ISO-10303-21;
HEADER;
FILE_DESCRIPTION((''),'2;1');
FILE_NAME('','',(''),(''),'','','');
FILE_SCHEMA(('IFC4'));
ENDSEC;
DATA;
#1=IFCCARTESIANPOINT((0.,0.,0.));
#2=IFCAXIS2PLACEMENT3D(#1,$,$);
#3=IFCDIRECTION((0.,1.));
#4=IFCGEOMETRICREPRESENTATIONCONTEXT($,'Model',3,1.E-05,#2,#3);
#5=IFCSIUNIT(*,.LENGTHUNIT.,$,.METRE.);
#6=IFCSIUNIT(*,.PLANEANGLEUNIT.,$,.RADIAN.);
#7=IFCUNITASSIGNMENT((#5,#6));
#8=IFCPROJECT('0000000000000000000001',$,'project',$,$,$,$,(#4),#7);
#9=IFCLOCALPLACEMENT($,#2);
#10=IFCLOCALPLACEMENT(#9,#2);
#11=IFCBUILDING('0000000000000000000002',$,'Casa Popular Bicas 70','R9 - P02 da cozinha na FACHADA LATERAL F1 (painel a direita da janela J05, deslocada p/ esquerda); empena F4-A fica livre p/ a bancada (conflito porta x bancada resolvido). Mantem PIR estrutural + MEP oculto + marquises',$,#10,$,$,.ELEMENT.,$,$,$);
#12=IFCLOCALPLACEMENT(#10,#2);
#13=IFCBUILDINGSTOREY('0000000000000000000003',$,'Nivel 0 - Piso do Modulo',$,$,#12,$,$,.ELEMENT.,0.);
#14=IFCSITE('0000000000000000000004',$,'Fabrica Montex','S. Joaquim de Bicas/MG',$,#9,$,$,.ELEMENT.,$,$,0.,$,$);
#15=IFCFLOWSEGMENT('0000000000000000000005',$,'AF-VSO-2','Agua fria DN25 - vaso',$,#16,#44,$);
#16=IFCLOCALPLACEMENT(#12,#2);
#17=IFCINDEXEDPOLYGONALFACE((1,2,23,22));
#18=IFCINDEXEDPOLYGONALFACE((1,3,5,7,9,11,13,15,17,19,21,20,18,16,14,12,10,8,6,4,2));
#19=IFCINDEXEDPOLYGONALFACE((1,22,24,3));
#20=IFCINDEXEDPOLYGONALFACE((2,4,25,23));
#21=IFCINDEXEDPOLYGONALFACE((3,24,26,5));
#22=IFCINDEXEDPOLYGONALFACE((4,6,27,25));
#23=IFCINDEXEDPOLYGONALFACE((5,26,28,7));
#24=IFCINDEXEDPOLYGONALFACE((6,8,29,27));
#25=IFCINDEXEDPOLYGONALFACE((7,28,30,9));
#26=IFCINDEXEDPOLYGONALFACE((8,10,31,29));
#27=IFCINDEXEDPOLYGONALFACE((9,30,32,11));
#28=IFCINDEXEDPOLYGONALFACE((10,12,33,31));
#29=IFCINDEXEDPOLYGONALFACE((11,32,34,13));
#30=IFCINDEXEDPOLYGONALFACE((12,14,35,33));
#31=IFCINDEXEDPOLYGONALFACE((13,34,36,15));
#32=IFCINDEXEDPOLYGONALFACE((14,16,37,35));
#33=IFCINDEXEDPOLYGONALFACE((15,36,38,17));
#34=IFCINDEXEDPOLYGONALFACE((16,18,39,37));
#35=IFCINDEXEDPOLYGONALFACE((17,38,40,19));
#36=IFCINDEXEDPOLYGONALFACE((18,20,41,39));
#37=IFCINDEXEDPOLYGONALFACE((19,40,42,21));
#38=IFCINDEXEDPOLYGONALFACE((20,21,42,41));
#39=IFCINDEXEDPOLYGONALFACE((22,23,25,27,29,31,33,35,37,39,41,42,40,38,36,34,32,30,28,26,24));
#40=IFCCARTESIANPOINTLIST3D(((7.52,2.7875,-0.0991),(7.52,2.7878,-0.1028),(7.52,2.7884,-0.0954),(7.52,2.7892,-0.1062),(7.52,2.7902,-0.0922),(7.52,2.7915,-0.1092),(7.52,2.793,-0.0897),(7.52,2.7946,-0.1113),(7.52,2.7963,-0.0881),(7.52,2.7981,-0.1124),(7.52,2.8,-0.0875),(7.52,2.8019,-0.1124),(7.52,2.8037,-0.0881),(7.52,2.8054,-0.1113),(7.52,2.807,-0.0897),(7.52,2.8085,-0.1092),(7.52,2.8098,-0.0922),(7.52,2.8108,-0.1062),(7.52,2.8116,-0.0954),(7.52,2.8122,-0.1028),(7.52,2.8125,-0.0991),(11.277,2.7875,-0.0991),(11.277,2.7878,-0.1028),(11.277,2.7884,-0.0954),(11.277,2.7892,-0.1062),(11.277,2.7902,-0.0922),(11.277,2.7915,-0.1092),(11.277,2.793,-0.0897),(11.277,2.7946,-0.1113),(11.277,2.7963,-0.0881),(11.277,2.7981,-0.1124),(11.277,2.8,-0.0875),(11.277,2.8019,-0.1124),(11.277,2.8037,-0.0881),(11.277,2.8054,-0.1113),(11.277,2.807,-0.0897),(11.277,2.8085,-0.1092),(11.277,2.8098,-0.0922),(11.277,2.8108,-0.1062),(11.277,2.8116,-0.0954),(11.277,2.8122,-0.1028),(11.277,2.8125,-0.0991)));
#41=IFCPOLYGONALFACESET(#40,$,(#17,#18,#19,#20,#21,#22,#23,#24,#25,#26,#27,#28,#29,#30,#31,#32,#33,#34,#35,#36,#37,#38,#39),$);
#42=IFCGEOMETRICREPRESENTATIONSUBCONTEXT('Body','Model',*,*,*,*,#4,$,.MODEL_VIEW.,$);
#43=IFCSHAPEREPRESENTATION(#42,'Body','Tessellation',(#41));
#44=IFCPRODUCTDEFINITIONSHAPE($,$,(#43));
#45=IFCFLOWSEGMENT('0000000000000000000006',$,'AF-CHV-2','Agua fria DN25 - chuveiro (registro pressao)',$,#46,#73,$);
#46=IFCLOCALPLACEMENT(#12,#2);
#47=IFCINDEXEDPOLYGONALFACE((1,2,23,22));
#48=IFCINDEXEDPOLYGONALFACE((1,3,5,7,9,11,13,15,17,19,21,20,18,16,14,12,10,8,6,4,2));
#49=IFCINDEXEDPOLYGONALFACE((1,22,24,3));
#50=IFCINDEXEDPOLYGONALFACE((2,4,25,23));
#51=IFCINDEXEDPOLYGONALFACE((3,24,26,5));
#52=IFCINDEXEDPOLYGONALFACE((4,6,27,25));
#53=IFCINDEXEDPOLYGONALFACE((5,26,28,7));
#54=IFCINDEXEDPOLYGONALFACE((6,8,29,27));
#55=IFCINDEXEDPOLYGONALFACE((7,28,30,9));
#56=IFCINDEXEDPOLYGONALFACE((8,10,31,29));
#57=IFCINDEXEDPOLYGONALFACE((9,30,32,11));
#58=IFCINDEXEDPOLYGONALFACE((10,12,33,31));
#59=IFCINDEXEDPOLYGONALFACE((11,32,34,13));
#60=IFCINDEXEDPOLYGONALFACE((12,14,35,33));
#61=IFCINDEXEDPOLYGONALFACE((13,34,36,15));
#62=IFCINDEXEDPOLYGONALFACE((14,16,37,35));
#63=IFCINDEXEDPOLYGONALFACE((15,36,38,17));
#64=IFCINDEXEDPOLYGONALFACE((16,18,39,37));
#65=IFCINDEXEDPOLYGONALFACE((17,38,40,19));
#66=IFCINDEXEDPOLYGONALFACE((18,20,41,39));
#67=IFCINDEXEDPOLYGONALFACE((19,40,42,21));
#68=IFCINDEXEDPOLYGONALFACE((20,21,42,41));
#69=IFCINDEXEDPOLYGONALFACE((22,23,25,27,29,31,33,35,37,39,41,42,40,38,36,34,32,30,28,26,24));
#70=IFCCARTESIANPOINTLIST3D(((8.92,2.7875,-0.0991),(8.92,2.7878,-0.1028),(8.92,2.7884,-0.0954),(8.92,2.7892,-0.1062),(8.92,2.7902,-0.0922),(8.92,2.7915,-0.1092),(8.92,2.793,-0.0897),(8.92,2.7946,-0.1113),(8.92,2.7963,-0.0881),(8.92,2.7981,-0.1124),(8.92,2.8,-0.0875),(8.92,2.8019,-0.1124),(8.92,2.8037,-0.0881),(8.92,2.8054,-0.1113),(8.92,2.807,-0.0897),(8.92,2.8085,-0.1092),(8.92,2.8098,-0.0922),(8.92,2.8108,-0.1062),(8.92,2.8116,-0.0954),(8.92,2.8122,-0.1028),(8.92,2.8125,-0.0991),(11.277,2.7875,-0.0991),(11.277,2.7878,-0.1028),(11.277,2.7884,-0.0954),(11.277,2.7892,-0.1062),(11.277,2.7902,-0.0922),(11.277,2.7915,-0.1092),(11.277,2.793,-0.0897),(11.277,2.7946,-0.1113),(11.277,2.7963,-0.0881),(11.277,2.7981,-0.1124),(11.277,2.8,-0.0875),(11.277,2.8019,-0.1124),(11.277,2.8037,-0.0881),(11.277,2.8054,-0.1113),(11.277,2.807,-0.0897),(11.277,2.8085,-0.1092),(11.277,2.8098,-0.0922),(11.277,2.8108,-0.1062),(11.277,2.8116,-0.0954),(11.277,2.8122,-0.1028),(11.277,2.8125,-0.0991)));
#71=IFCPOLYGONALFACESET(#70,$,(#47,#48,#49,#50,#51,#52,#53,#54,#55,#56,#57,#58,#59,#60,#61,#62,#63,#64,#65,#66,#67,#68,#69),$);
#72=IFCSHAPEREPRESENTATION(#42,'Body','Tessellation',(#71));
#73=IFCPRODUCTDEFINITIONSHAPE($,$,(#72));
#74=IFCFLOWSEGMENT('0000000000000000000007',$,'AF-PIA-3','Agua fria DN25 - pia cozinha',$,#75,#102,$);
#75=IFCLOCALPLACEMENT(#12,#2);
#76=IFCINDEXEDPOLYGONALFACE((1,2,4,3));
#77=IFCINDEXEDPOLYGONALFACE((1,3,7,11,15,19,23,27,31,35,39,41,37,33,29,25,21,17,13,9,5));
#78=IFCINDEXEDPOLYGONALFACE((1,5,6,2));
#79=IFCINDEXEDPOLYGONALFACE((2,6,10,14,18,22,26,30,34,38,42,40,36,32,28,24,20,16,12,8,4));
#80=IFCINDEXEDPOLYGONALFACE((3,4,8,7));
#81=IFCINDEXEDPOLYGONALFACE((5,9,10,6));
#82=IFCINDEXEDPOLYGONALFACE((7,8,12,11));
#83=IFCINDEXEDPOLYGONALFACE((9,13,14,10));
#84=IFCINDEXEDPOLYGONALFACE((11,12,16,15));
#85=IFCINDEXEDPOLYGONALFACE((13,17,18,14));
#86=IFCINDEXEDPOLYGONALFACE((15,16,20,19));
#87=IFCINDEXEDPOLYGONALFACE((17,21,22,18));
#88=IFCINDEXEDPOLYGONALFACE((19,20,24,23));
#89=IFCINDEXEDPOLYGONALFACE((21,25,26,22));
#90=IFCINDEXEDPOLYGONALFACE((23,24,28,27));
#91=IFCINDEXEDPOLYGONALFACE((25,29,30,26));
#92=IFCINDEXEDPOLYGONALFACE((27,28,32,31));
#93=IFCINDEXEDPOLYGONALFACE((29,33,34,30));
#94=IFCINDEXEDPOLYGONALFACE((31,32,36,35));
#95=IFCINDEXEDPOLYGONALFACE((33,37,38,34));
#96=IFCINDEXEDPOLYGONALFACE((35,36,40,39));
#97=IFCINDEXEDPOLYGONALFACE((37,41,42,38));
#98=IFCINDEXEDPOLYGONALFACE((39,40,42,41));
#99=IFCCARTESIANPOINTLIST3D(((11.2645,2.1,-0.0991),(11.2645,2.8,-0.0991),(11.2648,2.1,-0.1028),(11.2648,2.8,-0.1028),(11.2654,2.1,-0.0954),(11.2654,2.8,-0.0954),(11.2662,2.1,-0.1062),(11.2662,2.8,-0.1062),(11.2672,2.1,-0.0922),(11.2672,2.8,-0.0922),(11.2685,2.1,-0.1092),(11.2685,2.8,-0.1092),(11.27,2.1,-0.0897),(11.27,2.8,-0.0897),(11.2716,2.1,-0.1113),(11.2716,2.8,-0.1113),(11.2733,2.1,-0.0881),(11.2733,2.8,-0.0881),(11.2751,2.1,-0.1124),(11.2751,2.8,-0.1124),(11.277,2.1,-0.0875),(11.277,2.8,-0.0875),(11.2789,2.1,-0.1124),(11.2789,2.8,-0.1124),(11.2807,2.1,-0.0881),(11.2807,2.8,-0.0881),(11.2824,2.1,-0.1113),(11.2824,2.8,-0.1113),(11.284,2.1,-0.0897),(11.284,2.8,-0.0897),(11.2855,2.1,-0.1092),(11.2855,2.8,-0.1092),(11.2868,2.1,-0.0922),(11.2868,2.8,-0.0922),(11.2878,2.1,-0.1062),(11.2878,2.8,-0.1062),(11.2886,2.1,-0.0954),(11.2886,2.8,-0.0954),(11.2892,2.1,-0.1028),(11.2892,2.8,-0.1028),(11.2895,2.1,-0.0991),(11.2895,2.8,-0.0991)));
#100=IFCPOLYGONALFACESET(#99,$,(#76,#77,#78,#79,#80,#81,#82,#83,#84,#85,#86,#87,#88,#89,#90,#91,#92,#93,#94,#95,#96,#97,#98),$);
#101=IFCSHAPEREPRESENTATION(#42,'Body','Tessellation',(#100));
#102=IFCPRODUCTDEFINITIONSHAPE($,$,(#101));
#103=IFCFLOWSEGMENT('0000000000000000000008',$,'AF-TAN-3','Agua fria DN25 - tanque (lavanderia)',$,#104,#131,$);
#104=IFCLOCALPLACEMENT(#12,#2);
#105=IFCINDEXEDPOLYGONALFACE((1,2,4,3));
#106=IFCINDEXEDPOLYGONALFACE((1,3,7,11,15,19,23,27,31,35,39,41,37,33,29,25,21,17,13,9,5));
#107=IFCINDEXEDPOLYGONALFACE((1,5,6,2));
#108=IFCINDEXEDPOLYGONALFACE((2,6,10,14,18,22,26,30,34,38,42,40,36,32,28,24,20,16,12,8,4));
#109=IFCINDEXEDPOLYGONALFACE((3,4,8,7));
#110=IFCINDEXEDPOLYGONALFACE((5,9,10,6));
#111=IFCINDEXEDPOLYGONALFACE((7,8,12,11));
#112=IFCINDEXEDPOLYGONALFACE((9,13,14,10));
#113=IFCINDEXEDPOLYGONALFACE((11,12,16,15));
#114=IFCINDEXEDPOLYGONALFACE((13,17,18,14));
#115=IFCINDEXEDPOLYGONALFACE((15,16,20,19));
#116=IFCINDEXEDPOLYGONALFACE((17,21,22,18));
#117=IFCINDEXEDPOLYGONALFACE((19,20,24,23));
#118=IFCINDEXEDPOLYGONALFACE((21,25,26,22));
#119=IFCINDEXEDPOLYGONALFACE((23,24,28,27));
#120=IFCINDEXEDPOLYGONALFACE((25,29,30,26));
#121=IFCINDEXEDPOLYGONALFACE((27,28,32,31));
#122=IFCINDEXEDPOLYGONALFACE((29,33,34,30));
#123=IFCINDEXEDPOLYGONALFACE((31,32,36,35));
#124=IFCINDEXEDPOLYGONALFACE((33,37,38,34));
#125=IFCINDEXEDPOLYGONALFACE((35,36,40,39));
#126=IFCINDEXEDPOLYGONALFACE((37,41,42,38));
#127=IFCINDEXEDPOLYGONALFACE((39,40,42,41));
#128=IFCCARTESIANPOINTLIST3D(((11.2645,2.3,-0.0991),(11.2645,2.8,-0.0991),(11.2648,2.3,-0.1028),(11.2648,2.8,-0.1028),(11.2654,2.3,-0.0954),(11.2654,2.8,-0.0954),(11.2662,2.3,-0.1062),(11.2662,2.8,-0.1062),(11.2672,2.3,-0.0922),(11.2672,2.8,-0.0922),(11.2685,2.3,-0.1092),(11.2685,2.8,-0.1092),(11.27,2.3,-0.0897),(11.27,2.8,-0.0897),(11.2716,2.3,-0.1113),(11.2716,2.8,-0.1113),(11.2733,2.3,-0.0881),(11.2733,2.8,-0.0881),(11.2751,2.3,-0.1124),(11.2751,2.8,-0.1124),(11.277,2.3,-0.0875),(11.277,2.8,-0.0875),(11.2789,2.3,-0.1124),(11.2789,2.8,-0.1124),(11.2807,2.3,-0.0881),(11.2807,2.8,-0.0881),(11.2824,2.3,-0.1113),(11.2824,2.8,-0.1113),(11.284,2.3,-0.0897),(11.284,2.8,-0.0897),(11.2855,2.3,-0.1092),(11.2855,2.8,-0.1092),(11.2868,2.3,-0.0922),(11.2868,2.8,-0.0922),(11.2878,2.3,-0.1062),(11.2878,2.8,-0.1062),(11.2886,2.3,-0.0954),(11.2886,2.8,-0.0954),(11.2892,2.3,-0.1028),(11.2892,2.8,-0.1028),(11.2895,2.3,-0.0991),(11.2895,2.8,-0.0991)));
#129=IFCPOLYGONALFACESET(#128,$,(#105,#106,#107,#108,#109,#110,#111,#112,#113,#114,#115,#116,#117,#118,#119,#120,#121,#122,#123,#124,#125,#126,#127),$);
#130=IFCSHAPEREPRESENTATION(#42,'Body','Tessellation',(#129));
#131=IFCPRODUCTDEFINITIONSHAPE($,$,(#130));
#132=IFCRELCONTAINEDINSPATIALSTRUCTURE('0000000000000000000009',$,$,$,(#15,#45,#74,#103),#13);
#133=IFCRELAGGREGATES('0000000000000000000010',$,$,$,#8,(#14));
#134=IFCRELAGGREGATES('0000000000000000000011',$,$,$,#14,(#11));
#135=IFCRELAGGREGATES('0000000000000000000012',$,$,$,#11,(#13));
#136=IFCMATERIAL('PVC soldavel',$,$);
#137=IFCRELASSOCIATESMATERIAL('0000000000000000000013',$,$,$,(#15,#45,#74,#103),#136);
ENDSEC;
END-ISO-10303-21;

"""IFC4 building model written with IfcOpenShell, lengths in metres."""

from ifc_helpers import new_model, si_unit, direction, frame, origin, origin_2d, place, context, subcontext, project, spatial, circle, extrude, material, element, save


model = new_model("IFC4")

# Units and contexts
model_context = context("Model", 3, precision=1e-05, world=origin(), true_north=direction((0.0, 1.0)))
body_context = subcontext(model_context, "Body", "Model", "MODEL_VIEW")
ifc_project = project(units=[si_unit("LENGTHUNIT", "METRE"), si_unit("PLANEANGLEUNIT", "RADIAN")], contexts=[model_context])

# Site, building, storey
site_placement = place(None, origin())
site = spatial("IfcSite", under=ifc_project, at=site_placement, Name="Fabrica Montex", Description="S. Joaquim de Bicas/MG", CompositionType="ELEMENT", RefElevation=0.0)
building_placement = place(site_placement, origin())
building = spatial("IfcBuilding", under=site, at=building_placement, Name="Casa Popular Bicas 70", Description="R9 - P02 da cozinha na FACHADA LATERAL F1 (painel a direita da janela J05, deslocada p/ esquerda); empena F4-A fica livre p/ a bancada (conflito porta x bancada resolvido). Mantem PIR estrutural + MEP oculto + marquises", CompositionType="ELEMENT")
storey_placement = place(building_placement, origin())
storey = spatial("IfcBuildingStorey", under=building, at=storey_placement, Name="Nivel 0 - Piso do Modulo", CompositionType="ELEMENT", Elevation=0.0)

# Flow segments
ifc_material_1 = material(Name="PVC soldavel")
flow_segment_1_placement = place(None, frame((11.277, 2.8, -0.1), z_axis=(-1.0, 0.0, 0.0), x_axis=(0.0, 0.0, 1.0)))
element("IfcFlowSegment", 1, at=flow_segment_1_placement, inside=storey, material=ifc_material_1, Name="AF-VSO-2", Description="Agua fria DN25 - vaso", context=body_context, shape_type="SweptSolid", body=[
    extrude(circle(Radius=0.0125, at=origin_2d()), origin(), (0.0, 0.0, 1.0), 3.757),
])
flow_segment_2_placement = place(None, frame((11.277, 2.8, -0.1), z_axis=(-1.0, 0.0, 0.0), x_axis=(0.0, 0.0, 1.0)))
element("IfcFlowSegment", 2, at=flow_segment_2_placement, inside=storey, material=ifc_material_1, Name="AF-CHV-2", Description="Agua fria DN25 - chuveiro (registro pressao)", context=body_context, shape_type="SweptSolid", body=[
    extrude(circle(Radius=0.0125, at=origin_2d()), origin(), (0.0, 0.0, 1.0), 2.357),
])
flow_segment_3_placement = place(None, frame((11.277, 2.8, -0.1), z_axis=(0.0, -1.0, 0.0), x_axis=(0.0, 0.0, 1.0)))
element("IfcFlowSegment", 3, at=flow_segment_3_placement, inside=storey, material=ifc_material_1, Name="AF-PIA-3", Description="Agua fria DN25 - pia cozinha", context=body_context, shape_type="SweptSolid", body=[
    extrude(circle(Radius=0.0125, at=origin_2d()), origin(), (0.0, 0.0, 1.0), 0.7),
])
flow_segment_4_placement = place(None, frame((11.277, 2.8, -0.1), z_axis=(0.0, -1.0, 0.0), x_axis=(0.0, 0.0, 1.0)))
element("IfcFlowSegment", 4, at=flow_segment_4_placement, inside=storey, material=ifc_material_1, Name="AF-TAN-3", Description="Agua fria DN25 - tanque (lavanderia)", context=body_context, shape_type="SweptSolid", body=[
    extrude(circle(Radius=0.0125, at=origin_2d()), origin(), (0.0, 0.0, 1.0), 0.5),
])

save(model, "model.ifc")
